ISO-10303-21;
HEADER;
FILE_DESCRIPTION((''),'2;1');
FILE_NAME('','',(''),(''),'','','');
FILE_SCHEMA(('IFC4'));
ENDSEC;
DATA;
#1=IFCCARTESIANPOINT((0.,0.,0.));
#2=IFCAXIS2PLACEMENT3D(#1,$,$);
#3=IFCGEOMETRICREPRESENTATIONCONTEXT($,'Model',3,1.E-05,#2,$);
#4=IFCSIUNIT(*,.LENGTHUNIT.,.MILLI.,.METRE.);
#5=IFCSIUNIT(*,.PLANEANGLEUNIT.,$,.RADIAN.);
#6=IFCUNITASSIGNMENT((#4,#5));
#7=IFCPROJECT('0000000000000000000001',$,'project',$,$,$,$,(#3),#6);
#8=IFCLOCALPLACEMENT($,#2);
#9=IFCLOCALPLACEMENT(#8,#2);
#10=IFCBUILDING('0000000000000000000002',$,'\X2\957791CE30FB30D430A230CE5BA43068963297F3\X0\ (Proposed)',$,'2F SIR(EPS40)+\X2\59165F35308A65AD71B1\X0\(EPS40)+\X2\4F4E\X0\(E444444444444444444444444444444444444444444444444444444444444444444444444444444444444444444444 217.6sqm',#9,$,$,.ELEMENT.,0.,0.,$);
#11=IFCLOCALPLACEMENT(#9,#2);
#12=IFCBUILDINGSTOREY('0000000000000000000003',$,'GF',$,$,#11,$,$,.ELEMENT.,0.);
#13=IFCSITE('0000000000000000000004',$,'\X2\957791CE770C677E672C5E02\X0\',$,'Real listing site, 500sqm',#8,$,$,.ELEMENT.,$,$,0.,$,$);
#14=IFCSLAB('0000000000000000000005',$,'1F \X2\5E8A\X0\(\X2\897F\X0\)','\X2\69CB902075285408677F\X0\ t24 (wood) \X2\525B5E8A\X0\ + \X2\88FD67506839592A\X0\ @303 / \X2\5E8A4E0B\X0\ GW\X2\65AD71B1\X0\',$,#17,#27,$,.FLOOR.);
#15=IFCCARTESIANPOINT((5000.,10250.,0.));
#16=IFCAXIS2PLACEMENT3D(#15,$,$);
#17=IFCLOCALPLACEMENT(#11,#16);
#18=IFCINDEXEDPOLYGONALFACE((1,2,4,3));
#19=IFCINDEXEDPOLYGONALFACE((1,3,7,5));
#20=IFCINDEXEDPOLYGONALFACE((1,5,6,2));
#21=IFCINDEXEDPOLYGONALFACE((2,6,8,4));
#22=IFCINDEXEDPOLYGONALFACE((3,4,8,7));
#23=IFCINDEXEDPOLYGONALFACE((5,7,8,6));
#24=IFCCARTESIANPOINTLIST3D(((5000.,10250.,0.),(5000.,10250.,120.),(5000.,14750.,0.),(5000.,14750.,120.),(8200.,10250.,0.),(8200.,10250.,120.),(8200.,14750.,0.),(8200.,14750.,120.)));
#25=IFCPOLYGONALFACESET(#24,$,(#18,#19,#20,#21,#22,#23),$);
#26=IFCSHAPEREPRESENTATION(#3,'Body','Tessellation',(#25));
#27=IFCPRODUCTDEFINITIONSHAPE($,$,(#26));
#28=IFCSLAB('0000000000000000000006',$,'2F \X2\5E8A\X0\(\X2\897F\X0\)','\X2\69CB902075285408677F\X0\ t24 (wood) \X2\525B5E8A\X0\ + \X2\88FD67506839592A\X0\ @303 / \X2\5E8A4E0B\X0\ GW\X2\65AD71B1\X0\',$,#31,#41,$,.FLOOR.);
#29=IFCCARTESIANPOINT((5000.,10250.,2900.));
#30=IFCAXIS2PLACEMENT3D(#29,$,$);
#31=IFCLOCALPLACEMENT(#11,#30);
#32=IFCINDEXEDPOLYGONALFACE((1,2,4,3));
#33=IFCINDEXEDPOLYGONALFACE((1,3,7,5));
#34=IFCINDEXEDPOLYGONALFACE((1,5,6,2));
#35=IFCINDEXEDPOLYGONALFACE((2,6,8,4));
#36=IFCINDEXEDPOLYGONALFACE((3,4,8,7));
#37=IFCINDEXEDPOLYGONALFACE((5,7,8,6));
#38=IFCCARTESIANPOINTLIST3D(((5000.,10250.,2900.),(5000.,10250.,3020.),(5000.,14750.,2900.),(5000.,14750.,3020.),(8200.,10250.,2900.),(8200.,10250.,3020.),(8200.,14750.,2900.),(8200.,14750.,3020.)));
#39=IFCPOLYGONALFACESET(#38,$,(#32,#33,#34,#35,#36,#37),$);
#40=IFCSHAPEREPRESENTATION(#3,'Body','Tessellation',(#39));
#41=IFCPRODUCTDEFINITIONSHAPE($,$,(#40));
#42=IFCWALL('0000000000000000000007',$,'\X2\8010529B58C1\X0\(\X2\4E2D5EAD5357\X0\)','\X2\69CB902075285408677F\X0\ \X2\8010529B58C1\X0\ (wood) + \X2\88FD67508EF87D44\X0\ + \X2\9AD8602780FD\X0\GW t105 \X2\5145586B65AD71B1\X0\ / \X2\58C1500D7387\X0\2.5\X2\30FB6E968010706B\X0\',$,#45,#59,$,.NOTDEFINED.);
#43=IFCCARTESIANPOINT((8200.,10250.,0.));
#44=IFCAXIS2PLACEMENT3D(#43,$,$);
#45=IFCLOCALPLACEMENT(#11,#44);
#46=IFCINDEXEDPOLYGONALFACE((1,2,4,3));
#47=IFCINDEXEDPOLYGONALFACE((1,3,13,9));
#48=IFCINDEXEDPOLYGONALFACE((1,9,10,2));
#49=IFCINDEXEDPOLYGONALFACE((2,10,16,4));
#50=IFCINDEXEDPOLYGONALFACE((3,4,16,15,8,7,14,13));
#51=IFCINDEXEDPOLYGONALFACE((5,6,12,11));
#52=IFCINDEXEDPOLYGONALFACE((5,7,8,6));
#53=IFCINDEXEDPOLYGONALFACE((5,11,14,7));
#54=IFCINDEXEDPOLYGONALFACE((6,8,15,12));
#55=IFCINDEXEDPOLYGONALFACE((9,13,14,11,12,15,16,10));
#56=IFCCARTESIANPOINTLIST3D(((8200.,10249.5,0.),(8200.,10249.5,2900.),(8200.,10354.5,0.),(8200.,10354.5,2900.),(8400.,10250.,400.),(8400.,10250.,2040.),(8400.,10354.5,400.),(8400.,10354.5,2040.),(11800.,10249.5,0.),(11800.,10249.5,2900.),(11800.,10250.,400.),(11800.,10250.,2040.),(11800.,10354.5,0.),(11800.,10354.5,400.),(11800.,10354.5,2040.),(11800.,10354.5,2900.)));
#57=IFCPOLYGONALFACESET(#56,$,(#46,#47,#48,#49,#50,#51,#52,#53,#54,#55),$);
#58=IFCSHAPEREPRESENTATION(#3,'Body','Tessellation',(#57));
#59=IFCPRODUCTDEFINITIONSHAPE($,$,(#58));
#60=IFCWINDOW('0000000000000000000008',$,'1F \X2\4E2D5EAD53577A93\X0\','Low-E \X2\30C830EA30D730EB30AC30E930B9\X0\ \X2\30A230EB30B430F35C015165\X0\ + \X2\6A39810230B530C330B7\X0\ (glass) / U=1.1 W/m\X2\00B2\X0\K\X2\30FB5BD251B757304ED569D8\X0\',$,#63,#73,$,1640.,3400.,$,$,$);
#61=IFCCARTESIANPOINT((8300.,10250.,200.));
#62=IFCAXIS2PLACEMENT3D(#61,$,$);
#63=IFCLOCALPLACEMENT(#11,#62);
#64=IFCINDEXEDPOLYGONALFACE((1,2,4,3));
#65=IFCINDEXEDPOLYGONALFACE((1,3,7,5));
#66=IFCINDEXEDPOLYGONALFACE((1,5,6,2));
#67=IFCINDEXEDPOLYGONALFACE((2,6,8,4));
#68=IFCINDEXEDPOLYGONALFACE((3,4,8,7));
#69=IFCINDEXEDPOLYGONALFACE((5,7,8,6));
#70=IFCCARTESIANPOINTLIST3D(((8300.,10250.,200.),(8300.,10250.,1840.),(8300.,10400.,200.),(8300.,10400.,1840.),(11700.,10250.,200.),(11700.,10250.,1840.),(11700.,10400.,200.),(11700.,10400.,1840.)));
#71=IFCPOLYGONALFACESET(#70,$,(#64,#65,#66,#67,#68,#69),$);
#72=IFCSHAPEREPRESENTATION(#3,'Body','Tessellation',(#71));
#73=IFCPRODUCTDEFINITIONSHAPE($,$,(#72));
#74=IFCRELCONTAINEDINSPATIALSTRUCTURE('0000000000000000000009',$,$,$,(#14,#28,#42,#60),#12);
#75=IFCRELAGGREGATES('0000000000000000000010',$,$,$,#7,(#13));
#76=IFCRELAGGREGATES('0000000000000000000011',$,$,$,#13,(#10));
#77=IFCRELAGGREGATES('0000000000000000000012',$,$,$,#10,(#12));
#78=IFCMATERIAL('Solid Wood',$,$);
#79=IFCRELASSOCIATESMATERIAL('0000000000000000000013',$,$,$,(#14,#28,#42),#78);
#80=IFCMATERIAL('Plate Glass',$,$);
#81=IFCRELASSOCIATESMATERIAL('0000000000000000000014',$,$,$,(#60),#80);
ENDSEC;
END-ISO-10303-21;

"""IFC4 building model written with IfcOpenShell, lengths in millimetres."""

from ifc_helpers import new_model, si_unit, frame, frame_2d, origin, place, context, project, spatial, rectangle, extrude, material, element, fill, save


model = new_model("IFC4")

# Units and contexts
model_context = context("Model", 3, precision=1e-05, world=origin())
ifc_project = project(units=[si_unit("LENGTHUNIT", "METRE", prefix="MILLI"), si_unit("PLANEANGLEUNIT", "RADIAN")], contexts=[model_context])

# Site, building, storey
site_placement = place(None, origin())
site = spatial("IfcSite", under=ifc_project, at=site_placement, Name="長野県松本市", ObjectType="Real listing site, 500sqm", CompositionType="ELEMENT", RefElevation=0.0)
building_placement = place(site_placement, origin())
building = spatial("IfcBuilding", under=site, at=building_placement, Name="長野・ピアノ室と防音 (Proposed)", ObjectType="2F SIR(EPS40)+外張り断熱(EPS40)+低(E444444444444444444444444444444444444444444444444444444444444444444444444444444444444444444444 217.6sqm", CompositionType="ELEMENT", ElevationOfRefHeight=0.0, ElevationOfTerrain=0.0)
storey_placement = place(building_placement, origin())
storey = spatial("IfcBuildingStorey", under=building, at=storey_placement, Name="GF", CompositionType="ELEMENT", Elevation=0.0)

# Shared definitions
ifc_material_1 = material(Name="Solid Wood")

# Slabs
slab_1_placement = place(storey_placement, frame((5000.0, 10250.0, 0.0)))
element("IfcSlab", 1, at=slab_1_placement, inside=storey, material=ifc_material_1, Name="1F 床(西)", Description="構造用合板 t24 (wood) 剛床 + 製材根太 @303 / 床下 GW断熱", PredefinedType="FLOOR", context=model_context, shape_type="SweptSolid", body=[
    extrude(rectangle(XDim=3200.0, YDim=4500.0, at=frame_2d((1600.0, 2250.0))), frame((5000.0, 10250.0, 0.0)), (0.0, 0.0, 1.0), 120.0),
])
slab_2_placement = place(storey_placement, frame((5000.0, 10250.0, 2900.0)))
element("IfcSlab", 2, at=slab_2_placement, inside=storey, material=ifc_material_1, Name="2F 床(西)", Description="構造用合板 t24 (wood) 剛床 + 製材根太 @303 / 床下 GW断熱", PredefinedType="FLOOR", context=model_context, shape_type="SweptSolid", body=[
    extrude(rectangle(XDim=3200.0, YDim=4500.0, at=frame_2d((1600.0, 2250.0))), frame((5000.0, 10250.0, 2900.0)), (0.0, 0.0, 1.0), 120.0),
])

# Wall, opening, window
wall_placement = place(storey_placement, frame((8200.0, 10250.0, 0.0)))
wall = element("IfcWall", 3, at=wall_placement, inside=storey, material=ifc_material_1, Name="耐力壁(中庭南)", Description="構造用合板 耐力壁 (wood) + 製材軸組 + 高性能GW t105 充填断熱 / 壁倍率2.5・準耐火", PredefinedType="NOTDEFINED", context=model_context, shape_type="SweptSolid", body=[
    extrude(rectangle(XDim=3600.0, YDim=105.0, at=frame_2d((1800.0, 52.0))), frame((8200.0, 10250.0, 0.0)), (0.0, 0.0, 1.0), 2900.0),
])
opening_placement = place(storey_placement, frame((8300.0, 10250.0, 200.0)))
opening = element("IfcOpeningElement", 4, at=opening_placement, cuts=wall, PredefinedType="NOTDEFINED", context=model_context, shape_type="SweptSolid", body=[
    extrude(rectangle(XDim=3400.0, YDim=150.0, at=frame_2d((1700.0, 75.0))), frame((8300.0, 10250.0, 200.0)), (0.0, 0.0, 1.0), 1640.0),
])
ifc_material_2 = material(Name="Plate Glass")
window_placement = place(storey_placement, frame((8300.0, 10250.0, 200.0)))
window = element("IfcWindow", 5, at=window_placement, inside=storey, material=ifc_material_2, Name="1F 中庭南窓", Description="Low-E トリプルガラス アルゴン封入 + 樹脂サッシ (glass) / U=1.1 W/m²K・寒冷地仕様", OverallHeight=1640.0, OverallWidth=3400.0, context=model_context, shape_type="SweptSolid", body=[
    extrude(rectangle(XDim=3400.0, YDim=150.0, at=frame_2d((1700.0, 75.0))), frame((8300.0, 10250.0, 200.0)), (0.0, 0.0, 1.0), 1640.0),
])
fill(opening, window)

save(model, "model.ifc")
